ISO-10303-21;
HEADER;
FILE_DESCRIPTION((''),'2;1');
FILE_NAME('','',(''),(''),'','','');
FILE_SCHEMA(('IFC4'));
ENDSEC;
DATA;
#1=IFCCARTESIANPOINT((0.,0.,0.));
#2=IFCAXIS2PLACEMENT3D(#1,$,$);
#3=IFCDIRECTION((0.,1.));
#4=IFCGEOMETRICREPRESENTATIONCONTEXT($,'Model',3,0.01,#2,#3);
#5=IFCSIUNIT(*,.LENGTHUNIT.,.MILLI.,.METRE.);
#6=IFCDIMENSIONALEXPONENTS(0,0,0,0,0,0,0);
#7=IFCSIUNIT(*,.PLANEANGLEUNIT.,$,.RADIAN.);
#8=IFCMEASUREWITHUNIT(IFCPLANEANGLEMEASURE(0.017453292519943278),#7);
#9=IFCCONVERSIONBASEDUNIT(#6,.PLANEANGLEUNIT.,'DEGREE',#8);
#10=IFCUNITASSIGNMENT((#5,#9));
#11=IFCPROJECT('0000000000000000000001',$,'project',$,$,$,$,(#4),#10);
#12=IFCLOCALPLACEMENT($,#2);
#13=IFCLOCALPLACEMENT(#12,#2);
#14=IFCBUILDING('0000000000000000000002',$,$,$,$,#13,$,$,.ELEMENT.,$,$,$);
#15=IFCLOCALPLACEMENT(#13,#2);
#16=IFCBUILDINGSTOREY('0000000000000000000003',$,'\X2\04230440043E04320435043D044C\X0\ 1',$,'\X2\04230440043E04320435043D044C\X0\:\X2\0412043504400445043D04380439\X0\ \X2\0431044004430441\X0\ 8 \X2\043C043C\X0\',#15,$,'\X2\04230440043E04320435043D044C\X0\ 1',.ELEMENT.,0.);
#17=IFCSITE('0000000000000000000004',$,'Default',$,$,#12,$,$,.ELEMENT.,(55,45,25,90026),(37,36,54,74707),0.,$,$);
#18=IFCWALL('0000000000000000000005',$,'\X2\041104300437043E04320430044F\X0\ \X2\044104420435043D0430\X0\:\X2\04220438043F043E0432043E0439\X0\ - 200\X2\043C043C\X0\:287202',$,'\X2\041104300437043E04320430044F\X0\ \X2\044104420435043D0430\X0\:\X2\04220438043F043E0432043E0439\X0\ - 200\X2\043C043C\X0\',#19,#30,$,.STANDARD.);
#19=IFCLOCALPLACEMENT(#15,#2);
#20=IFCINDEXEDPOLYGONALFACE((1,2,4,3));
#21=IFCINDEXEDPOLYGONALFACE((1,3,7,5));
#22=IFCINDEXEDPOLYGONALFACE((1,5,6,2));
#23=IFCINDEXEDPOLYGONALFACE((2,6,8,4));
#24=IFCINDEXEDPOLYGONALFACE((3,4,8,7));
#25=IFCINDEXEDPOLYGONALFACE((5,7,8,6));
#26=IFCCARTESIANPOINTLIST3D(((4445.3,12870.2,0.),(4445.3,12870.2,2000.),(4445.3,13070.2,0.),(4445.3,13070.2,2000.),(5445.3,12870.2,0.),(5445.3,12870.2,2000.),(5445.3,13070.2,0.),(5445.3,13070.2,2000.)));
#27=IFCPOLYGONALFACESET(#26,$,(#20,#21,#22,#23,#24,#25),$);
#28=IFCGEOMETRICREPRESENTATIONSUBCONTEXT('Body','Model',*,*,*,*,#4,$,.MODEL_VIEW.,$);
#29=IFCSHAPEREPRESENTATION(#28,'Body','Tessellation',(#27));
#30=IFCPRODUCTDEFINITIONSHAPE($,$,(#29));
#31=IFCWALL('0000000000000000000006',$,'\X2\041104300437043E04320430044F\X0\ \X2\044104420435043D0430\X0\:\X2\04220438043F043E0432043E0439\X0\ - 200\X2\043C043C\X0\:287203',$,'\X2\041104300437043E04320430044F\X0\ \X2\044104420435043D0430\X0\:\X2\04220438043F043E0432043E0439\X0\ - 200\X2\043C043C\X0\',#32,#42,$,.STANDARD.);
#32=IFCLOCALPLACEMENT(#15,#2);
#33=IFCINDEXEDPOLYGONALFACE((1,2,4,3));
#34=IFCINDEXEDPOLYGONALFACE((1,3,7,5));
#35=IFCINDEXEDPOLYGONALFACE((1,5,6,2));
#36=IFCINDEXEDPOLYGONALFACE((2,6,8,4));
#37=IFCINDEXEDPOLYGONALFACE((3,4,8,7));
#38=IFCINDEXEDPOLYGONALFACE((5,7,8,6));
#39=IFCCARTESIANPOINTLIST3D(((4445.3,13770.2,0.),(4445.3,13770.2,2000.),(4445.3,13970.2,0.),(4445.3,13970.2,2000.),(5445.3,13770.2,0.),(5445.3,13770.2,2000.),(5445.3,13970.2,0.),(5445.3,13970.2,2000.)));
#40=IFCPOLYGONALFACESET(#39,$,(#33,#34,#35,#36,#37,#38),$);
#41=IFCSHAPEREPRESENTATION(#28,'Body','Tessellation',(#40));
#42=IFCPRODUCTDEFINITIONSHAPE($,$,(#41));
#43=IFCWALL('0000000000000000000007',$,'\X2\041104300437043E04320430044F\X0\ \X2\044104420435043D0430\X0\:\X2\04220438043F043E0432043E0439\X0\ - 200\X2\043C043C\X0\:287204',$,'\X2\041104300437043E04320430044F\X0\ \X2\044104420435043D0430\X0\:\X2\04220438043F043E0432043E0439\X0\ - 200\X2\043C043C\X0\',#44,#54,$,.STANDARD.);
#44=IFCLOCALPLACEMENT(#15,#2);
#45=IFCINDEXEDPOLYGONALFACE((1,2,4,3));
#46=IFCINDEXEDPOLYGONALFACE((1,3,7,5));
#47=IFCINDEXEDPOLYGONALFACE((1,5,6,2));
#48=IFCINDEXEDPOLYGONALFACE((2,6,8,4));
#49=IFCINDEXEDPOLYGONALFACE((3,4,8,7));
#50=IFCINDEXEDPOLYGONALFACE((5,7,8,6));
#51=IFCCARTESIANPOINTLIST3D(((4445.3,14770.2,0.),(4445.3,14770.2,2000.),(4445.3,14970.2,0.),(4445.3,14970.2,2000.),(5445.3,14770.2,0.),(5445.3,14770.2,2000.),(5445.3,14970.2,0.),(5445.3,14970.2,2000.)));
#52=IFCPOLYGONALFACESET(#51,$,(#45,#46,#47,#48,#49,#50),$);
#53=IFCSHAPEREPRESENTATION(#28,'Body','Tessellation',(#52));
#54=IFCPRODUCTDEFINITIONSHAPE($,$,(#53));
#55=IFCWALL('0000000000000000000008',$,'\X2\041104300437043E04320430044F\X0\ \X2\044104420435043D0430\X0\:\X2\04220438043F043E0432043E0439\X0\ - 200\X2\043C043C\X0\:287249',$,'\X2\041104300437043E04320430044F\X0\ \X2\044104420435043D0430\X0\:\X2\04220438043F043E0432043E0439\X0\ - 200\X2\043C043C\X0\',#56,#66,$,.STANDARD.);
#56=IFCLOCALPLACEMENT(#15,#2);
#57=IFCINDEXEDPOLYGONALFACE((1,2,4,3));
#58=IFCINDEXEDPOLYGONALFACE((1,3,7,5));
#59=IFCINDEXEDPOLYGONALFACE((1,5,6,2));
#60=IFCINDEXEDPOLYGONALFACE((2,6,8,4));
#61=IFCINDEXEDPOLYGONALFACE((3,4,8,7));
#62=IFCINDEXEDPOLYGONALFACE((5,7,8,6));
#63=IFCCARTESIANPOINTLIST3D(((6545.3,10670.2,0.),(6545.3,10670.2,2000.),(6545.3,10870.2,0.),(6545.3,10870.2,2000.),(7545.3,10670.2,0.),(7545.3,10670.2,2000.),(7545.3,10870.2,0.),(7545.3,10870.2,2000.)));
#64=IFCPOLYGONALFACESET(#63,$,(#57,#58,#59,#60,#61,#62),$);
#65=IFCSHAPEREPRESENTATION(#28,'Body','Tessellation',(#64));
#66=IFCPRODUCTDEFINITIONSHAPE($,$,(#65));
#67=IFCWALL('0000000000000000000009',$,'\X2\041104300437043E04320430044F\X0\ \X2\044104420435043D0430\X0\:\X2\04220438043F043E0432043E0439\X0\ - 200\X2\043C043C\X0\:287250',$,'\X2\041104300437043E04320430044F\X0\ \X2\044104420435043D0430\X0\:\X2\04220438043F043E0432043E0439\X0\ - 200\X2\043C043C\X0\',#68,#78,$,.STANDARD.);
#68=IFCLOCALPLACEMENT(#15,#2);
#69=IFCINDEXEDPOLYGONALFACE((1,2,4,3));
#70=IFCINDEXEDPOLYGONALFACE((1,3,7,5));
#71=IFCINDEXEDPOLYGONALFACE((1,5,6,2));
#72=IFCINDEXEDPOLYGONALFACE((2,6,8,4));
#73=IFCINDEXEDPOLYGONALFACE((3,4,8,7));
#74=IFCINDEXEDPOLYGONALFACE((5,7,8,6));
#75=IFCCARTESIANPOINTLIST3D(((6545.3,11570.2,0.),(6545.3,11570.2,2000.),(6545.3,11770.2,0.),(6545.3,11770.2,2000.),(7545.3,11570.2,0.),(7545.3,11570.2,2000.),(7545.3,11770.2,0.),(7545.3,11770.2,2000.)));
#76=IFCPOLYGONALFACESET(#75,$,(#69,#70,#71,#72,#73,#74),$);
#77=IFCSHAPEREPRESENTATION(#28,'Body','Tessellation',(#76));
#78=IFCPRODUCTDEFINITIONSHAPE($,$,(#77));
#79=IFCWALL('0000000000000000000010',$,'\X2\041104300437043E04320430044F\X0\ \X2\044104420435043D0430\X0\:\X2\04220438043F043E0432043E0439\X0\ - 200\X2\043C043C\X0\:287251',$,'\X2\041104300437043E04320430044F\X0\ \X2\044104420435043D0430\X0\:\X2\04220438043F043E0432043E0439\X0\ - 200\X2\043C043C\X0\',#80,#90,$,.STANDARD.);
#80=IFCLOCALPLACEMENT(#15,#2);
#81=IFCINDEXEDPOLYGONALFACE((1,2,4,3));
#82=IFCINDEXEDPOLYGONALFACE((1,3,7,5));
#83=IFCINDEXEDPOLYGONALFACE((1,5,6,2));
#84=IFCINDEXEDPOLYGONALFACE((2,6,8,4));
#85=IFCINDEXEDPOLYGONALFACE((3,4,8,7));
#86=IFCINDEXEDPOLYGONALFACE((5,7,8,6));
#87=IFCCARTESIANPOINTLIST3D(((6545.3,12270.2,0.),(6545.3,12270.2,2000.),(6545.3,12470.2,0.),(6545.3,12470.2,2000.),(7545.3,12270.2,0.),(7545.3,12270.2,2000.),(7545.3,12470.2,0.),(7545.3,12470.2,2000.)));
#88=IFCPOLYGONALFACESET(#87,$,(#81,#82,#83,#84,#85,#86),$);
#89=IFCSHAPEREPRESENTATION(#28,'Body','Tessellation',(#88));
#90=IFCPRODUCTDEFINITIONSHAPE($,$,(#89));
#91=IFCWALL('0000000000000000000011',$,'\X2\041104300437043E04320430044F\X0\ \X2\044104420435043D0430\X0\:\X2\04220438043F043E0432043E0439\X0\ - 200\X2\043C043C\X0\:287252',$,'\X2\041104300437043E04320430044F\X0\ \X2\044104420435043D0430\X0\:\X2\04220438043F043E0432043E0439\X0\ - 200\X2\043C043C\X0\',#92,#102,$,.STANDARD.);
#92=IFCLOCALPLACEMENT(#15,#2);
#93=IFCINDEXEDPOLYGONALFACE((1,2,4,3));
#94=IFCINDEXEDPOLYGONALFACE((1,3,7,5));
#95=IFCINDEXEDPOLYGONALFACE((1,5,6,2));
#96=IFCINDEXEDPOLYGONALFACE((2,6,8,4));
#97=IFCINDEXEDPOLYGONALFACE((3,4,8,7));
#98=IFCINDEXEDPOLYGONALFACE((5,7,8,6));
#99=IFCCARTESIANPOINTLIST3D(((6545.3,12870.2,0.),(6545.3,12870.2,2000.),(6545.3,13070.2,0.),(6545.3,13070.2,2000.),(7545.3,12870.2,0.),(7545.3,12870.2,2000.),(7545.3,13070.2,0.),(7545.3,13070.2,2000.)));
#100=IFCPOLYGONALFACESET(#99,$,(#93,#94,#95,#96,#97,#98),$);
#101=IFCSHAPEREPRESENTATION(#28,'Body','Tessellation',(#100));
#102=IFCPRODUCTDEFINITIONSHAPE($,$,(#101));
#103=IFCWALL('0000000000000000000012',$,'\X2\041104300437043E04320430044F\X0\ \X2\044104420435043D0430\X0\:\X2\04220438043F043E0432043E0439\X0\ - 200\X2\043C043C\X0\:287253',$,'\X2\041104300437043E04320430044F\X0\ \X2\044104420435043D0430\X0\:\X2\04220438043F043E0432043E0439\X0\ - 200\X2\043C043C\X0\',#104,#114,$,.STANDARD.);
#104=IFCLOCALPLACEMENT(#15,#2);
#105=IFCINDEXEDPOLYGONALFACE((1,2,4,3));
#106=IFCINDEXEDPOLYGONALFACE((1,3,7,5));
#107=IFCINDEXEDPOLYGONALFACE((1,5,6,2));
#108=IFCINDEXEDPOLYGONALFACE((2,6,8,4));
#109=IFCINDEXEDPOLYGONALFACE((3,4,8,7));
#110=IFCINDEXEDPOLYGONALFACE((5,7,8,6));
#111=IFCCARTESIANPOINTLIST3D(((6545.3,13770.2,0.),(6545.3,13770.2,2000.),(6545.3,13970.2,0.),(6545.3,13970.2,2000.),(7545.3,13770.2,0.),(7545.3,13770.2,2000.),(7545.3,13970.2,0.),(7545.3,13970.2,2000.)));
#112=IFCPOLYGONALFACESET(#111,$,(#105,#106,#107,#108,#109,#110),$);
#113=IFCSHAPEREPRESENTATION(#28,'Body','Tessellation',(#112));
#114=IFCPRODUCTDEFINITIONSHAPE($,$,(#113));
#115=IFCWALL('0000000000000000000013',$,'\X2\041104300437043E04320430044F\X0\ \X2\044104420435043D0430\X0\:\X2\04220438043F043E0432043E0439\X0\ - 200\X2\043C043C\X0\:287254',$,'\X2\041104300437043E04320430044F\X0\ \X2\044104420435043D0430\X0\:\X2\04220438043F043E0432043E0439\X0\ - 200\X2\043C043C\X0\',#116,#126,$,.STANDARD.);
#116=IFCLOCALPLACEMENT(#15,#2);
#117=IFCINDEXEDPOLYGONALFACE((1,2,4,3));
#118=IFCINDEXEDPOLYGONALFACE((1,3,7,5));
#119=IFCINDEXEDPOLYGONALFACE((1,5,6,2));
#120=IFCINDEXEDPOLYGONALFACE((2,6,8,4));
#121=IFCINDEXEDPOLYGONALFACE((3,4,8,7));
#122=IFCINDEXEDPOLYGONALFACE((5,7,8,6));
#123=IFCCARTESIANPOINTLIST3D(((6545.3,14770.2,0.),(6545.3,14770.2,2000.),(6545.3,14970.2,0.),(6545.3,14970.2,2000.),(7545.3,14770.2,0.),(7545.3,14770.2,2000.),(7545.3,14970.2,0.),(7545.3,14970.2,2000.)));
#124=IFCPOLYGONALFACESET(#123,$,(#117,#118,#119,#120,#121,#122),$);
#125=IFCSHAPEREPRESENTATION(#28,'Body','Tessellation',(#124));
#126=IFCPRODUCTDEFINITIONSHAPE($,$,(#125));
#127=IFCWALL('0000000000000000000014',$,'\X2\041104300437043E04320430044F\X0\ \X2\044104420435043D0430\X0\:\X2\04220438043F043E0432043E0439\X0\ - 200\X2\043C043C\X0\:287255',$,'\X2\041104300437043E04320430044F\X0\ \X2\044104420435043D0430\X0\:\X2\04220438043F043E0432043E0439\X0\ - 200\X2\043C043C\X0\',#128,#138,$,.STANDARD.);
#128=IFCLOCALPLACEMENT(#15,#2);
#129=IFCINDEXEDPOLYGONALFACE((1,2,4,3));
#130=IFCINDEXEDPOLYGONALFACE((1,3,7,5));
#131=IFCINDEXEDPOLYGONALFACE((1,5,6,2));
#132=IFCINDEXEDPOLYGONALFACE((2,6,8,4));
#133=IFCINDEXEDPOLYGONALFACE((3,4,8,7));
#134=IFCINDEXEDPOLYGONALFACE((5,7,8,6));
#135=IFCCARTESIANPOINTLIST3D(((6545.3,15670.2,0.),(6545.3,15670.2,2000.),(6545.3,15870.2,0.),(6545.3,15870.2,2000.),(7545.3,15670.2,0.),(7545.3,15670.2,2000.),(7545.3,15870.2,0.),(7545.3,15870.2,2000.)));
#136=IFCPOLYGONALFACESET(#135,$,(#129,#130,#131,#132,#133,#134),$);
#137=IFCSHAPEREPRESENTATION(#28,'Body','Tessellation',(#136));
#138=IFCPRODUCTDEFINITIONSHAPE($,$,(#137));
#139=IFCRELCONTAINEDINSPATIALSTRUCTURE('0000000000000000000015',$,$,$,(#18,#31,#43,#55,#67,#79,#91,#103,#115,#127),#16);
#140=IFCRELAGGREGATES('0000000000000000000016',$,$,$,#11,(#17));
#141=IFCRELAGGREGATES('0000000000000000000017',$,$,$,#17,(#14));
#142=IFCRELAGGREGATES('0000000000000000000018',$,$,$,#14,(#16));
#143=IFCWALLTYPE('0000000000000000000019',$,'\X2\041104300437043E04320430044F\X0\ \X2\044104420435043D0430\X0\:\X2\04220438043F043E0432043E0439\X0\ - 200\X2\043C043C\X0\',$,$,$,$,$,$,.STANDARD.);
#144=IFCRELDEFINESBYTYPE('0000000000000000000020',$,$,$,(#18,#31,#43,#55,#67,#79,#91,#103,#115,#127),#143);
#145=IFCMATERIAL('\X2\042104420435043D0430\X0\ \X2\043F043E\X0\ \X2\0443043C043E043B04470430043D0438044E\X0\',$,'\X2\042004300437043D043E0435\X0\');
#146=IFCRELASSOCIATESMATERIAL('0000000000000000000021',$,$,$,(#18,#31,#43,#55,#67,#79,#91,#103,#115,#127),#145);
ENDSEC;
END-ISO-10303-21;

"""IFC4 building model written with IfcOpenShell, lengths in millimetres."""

from ifc_helpers import new_model, entity, si_unit, converted_unit, direction, frame, origin, place, context, subcontext, project, spatial, indexed_curve, outline, extrude, material, type_object, element, save


model = new_model("IFC4")

# Units and contexts
model_context = context("Model", 3, precision=0.01, world=origin(), true_north=direction((0.0, 1.0)))
body_context = subcontext(model_context, "Body", "Model", "MODEL_VIEW")
ifc_project = project(units=[si_unit("LENGTHUNIT", "METRE", prefix="MILLI"), converted_unit("PLANEANGLEUNIT", "DEGREE", entity("IfcPlaneAngleMeasure", 0.017453292519943278), si_unit("PLANEANGLEUNIT", "RADIAN"), dimensions=[0, 0, 0, 0, 0, 0, 0])], contexts=[model_context])

# Site, building, storey
site_placement = place(None, origin())
site = spatial("IfcSite", under=ifc_project, at=site_placement, Name="Default", CompositionType="ELEMENT", RefLatitude=(55, 45, 25, 90026), RefLongitude=(37, 36, 54, 74707), RefElevation=0.0)
building_placement = place(site_placement, origin())
building = spatial("IfcBuilding", under=site, at=building_placement, CompositionType="ELEMENT")
storey_placement = place(building_placement, origin())
storey = spatial("IfcBuildingStorey", under=building, at=storey_placement, Name="Уровень 1", ObjectType="Уровень:Верхний брус 8 мм", LongName="Уровень 1", CompositionType="ELEMENT", Elevation=0.0)

# Walls
ifc_material = material(Name="Стена по умолчанию", Category="Разное")
wall_type = type_object("IfcWallType", Name="Базовая стена:Типовой - 200мм", PredefinedType="STANDARD")
wall_1_placement = place(storey_placement, frame((4445.3, 12970.2, 0.0)))
element("IfcWall", 1, at=wall_1_placement, inside=storey, type_object=wall_type, material=ifc_material, Name="Базовая стена:Типовой - 200мм:287202", ObjectType="Базовая стена:Типовой - 200мм", PredefinedType="STANDARD", context=body_context, shape_type="SweptSolid", body=[
    extrude(outline(indexed_curve([(1000.0, 100.0), (0.0, 100.0), (0.0, -100.0), (1000.0, -100.0), (1000.0, 100.0)], self_intersect=False)), origin(), (0.0, 0.0, 1.0), 2000.0),
])
wall_2_placement = place(storey_placement, frame((4445.3, 13870.2, 0.0)))
element("IfcWall", 2, at=wall_2_placement, inside=storey, type_object=wall_type, material=ifc_material, Name="Базовая стена:Типовой - 200мм:287203", ObjectType="Базовая стена:Типовой - 200мм", PredefinedType="STANDARD", context=body_context, shape_type="SweptSolid", body=[
    extrude(outline(indexed_curve([(1000.0, 100.0), (0.0, 100.0), (0.0, -100.0), (1000.0, -100.0), (1000.0, 100.0)], self_intersect=False)), origin(), (0.0, 0.0, 1.0), 2000.0),
])
wall_3_placement = place(storey_placement, frame((4445.3, 14870.2, 0.0)))
element("IfcWall", 3, at=wall_3_placement, inside=storey, type_object=wall_type, material=ifc_material, Name="Базовая стена:Типовой - 200мм:287204", ObjectType="Базовая стена:Типовой - 200мм", PredefinedType="STANDARD", context=body_context, shape_type="SweptSolid", body=[
    extrude(outline(indexed_curve([(1000.0, 100.0), (0.0, 100.0), (0.0, -100.0), (1000.0, -100.0), (1000.0, 100.0)], self_intersect=False)), origin(), (0.0, 0.0, 1.0), 2000.0),
])
wall_4_placement = place(storey_placement, frame((6545.3, 10770.2, 0.0)))
element("IfcWall", 4, at=wall_4_placement, inside=storey, type_object=wall_type, material=ifc_material, Name="Базовая стена:Типовой - 200мм:287249", ObjectType="Базовая стена:Типовой - 200мм", PredefinedType="STANDARD", context=body_context, shape_type="SweptSolid", body=[
    extrude(outline(indexed_curve([(1000.0, 100.0), (0.0, 100.0), (0.0, -100.0), (1000.0, -100.0), (1000.0, 100.0)], self_intersect=False)), origin(), (0.0, 0.0, 1.0), 2000.0),
])
for number, where, name in (
    (5, (6545.3, 11670.2, 0.0), "Базовая стена:Типовой - 200мм:287250"),
    (6, (6545.3, 12370.2, 0.0), "Базовая стена:Типовой - 200мм:287251"),
):
    element("IfcWall", number, at=place(storey_placement, frame(where)), inside=storey, type_object=wall_type, material=ifc_material, Name=name, ObjectType="Базовая стена:Типовой - 200мм", PredefinedType="STANDARD", context=body_context, shape_type="SweptSolid", body=[
        extrude(outline(indexed_curve([(1000.0, 100.0), (0.0, 100.0), (0.0, -100.0), (1000.0, -100.0), (1000.0, 100.0)], self_intersect=False)), origin(), (0.0, 0.0, 1.0), 2000.0),
    ])
wall_5_placement = place(storey_placement, frame((6545.3, 12970.2, 0.0)))
element("IfcWall", 7, at=wall_5_placement, inside=storey, type_object=wall_type, material=ifc_material, Name="Базовая стена:Типовой - 200мм:287252", ObjectType="Базовая стена:Типовой - 200мм", PredefinedType="STANDARD", context=body_context, shape_type="SweptSolid", body=[
    extrude(outline(indexed_curve([(1000.0, 100.0), (0.0, 100.0), (0.0, -100.0), (1000.0, -100.0), (1000.0, 100.0)], self_intersect=False)), origin(), (0.0, 0.0, 1.0), 2000.0),
])
wall_6_placement = place(storey_placement, frame((6545.3, 13870.2, 0.0)))
element("IfcWall", 8, at=wall_6_placement, inside=storey, type_object=wall_type, material=ifc_material, Name="Базовая стена:Типовой - 200мм:287253", ObjectType="Базовая стена:Типовой - 200мм", PredefinedType="STANDARD", context=body_context, shape_type="SweptSolid", body=[
    extrude(outline(indexed_curve([(1000.0, 100.0), (0.0, 100.0), (0.0, -100.0), (1000.0, -100.0), (1000.0, 100.0)], self_intersect=False)), origin(), (0.0, 0.0, 1.0), 2000.0),
])
for number, where, name in (
    (9, (6545.3, 14870.2, 0.0), "Базовая стена:Типовой - 200мм:287254"),
    (10, (6545.3, 15770.2, 0.0), "Базовая стена:Типовой - 200мм:287255"),
):
    element("IfcWall", number, at=place(storey_placement, frame(where)), inside=storey, type_object=wall_type, material=ifc_material, Name=name, ObjectType="Базовая стена:Типовой - 200мм", PredefinedType="STANDARD", context=body_context, shape_type="SweptSolid", body=[
        extrude(outline(indexed_curve([(1000.0, 100.0), (0.0, 100.0), (0.0, -100.0), (1000.0, -100.0), (1000.0, 100.0)], self_intersect=False)), origin(), (0.0, 0.0, 1.0), 2000.0),
    ])

save(model, "model.ifc")
